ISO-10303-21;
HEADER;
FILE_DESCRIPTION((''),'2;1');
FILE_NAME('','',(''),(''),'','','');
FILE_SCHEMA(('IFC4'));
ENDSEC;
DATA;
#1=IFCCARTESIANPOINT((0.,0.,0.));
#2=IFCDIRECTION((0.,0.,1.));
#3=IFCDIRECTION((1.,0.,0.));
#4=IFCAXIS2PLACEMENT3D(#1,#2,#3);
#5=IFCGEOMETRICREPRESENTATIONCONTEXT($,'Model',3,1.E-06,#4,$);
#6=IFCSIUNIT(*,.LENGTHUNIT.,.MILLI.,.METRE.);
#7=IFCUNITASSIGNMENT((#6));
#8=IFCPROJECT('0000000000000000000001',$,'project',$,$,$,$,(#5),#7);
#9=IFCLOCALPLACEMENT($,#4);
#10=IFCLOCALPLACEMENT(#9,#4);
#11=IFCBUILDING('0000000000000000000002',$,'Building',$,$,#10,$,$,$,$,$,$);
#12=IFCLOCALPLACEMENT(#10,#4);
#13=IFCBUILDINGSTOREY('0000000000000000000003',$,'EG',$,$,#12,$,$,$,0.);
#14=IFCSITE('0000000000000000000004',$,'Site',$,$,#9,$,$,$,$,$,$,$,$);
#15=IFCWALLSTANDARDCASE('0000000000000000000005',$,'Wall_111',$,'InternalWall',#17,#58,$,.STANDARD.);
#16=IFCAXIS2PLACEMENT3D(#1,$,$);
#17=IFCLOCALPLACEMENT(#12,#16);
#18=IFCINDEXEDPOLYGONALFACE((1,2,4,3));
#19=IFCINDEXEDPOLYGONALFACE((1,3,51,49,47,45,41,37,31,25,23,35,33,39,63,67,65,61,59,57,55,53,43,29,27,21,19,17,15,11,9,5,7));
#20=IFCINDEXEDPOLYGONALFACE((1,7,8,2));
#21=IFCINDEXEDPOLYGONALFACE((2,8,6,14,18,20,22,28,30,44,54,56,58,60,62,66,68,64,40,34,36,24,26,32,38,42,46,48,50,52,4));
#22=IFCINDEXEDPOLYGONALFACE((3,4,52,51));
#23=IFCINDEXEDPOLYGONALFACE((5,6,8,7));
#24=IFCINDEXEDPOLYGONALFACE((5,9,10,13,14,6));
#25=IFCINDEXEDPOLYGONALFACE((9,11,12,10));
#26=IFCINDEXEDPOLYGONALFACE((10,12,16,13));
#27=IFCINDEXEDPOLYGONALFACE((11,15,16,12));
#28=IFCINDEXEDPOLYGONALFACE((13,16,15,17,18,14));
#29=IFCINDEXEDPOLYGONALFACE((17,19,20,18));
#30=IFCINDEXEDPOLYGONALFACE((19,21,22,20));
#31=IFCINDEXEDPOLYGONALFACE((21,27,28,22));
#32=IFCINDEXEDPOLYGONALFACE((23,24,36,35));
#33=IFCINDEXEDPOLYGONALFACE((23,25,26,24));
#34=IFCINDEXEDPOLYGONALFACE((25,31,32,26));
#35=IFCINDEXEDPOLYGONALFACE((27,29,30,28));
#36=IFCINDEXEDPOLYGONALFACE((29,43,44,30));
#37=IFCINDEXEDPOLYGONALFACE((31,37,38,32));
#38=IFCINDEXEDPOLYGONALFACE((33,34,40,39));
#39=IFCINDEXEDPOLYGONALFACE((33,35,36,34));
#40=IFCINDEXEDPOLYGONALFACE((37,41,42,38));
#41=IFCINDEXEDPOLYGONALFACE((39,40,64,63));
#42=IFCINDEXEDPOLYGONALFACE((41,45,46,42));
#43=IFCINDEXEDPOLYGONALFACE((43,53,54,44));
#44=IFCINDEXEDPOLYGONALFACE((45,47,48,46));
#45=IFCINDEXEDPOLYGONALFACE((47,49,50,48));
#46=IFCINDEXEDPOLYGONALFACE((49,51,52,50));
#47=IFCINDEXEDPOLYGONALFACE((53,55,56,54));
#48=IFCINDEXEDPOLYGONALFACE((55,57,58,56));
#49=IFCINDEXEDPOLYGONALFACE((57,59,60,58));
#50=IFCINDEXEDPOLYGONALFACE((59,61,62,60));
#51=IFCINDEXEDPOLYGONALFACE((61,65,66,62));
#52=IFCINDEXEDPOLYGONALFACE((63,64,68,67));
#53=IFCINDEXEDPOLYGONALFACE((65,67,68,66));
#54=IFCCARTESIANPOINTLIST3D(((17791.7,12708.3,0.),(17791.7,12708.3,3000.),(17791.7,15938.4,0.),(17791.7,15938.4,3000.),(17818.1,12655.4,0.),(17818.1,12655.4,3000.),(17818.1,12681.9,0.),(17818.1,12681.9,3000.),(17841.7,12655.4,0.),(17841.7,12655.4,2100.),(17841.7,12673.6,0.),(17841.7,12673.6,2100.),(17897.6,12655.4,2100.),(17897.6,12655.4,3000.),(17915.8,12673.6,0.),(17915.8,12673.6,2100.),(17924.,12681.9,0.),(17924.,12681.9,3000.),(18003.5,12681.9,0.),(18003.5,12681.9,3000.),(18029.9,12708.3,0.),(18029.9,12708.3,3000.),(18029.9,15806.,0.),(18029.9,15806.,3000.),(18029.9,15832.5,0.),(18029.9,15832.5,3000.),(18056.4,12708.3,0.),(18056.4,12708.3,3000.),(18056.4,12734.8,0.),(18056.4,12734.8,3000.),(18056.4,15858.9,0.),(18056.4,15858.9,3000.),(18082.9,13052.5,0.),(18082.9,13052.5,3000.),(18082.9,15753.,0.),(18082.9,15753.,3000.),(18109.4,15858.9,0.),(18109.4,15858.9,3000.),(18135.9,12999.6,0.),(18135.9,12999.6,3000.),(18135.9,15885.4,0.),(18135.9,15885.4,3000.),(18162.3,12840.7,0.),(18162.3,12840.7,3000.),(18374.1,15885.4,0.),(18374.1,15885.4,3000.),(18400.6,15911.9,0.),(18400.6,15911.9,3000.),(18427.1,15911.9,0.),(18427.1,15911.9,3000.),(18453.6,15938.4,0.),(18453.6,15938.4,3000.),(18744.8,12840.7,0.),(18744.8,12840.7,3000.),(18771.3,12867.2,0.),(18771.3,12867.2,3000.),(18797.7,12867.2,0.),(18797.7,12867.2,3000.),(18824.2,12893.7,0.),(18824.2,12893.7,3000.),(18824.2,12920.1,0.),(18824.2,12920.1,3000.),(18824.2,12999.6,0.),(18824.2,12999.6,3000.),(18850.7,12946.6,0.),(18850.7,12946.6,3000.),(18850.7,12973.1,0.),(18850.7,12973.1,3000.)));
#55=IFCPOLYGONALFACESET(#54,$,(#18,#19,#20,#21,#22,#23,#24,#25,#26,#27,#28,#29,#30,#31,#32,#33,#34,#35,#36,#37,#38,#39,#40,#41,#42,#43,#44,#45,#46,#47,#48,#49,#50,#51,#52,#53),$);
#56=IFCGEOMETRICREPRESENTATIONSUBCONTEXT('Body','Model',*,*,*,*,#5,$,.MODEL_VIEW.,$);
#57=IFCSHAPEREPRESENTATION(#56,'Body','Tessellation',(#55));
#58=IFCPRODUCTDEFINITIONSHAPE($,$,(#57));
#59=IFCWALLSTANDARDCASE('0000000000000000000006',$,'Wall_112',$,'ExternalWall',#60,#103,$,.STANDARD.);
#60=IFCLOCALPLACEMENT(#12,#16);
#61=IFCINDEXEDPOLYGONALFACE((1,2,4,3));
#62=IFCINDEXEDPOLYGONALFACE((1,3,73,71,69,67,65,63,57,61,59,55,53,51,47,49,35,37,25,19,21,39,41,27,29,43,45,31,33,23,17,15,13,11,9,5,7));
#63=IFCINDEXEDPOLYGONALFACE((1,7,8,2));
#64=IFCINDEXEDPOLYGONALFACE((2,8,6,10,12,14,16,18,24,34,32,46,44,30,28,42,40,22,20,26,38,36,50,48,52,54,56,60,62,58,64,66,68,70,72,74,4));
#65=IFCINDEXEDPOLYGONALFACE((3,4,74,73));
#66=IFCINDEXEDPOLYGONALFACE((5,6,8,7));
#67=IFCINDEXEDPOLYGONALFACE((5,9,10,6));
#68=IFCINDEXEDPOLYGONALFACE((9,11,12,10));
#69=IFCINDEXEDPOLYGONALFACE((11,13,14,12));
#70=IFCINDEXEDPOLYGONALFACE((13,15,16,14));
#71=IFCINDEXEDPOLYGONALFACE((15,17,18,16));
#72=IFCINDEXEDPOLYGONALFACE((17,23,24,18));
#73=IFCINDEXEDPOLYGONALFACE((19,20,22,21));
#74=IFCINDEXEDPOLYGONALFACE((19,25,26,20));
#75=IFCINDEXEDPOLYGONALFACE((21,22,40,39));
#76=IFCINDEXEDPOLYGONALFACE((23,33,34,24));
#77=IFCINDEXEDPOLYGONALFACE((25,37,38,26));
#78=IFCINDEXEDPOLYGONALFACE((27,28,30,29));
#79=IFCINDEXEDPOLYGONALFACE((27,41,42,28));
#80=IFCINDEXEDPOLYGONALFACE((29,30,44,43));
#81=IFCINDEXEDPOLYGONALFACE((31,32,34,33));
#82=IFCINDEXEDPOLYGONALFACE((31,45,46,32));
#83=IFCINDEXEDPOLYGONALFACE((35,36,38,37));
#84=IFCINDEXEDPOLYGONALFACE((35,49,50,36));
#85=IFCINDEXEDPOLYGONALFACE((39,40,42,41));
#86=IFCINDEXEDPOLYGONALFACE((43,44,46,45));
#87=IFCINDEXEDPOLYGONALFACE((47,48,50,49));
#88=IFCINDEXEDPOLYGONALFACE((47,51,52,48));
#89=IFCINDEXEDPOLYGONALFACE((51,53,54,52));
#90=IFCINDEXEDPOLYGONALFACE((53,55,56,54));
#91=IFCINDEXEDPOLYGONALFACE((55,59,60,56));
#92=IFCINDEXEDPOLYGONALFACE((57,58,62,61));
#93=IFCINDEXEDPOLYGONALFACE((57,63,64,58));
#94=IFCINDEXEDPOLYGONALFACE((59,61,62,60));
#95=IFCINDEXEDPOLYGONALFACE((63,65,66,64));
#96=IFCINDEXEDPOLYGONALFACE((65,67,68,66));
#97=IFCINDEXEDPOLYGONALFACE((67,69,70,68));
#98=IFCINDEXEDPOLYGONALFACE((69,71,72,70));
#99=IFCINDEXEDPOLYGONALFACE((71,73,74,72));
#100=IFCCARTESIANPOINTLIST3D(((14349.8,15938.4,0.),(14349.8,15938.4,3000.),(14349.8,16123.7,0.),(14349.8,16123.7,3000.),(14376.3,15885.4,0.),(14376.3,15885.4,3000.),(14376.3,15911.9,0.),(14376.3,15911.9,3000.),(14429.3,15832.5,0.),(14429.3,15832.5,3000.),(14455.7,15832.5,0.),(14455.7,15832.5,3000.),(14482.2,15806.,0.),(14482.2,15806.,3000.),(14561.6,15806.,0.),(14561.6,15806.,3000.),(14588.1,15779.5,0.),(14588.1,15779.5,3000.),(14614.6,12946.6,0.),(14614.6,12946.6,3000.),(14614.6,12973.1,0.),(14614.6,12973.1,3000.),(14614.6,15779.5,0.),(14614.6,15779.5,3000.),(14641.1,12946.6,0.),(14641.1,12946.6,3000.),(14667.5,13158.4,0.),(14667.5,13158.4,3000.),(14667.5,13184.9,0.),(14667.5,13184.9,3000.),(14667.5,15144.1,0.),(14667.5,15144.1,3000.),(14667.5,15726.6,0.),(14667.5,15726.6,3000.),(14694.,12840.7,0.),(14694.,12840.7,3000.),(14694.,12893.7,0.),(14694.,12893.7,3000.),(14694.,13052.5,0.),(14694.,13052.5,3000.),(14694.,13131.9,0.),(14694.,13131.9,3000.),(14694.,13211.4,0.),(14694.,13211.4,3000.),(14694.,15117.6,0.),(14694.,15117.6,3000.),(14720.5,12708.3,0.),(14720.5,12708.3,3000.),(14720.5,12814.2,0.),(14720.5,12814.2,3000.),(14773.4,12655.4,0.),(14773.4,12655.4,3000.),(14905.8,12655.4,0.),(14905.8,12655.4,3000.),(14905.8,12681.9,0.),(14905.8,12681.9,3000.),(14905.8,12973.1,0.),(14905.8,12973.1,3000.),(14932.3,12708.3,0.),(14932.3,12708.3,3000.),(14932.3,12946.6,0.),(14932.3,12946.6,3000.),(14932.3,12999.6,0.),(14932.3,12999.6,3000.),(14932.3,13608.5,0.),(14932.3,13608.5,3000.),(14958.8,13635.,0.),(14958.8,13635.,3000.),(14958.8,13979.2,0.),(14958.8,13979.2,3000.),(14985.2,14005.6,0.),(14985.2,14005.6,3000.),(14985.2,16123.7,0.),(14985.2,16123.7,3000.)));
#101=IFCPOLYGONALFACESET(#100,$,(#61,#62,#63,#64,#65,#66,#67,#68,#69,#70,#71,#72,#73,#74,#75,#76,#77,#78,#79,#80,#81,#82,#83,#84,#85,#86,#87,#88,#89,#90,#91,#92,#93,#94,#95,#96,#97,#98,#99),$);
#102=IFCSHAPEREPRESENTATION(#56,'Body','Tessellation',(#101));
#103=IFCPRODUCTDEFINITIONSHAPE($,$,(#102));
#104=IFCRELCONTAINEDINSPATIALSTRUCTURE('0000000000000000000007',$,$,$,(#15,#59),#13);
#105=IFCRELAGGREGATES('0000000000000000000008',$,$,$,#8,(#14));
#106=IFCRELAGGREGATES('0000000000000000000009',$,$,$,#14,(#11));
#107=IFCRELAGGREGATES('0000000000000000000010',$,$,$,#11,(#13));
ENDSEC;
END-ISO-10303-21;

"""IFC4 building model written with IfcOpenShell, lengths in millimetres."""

from ifc_helpers import new_model, si_unit, frame, origin_with_axes, place, context, subcontext, project, spatial, polyline, rectangle, outline, extrude, element, save


model = new_model("IFC4")

# Units and contexts
model_context = context("Model", 3, precision=1e-06, world=origin_with_axes())
body_context = subcontext(model_context, "Body", "Model", "MODEL_VIEW")
ifc_project = project(units=[si_unit("LENGTHUNIT", "METRE", prefix="MILLI")], contexts=[model_context])

# Site, building, storey
site_placement = place(None, origin_with_axes())
site = spatial("IfcSite", under=ifc_project, at=site_placement, Name="Site")
building_placement = place(site_placement, origin_with_axes())
building = spatial("IfcBuilding", under=site, at=building_placement, Name="Building")
storey_placement = place(building_placement, origin_with_axes())
storey = spatial("IfcBuildingStorey", under=building, at=storey_placement, Name="EG", Elevation=0.0)

# Wall, opening
wall_1_placement = place(storey_placement, origin_with_axes())
wall_1 = element("IfcWallStandardCase", 1, at=wall_1_placement, inside=storey, Name="Wall_111", ObjectType="InternalWall", PredefinedType="STANDARD", context=body_context, shape_type="SweptSolid", body=[
    extrude(outline(polyline([(17818.1, 12655.4, 0.0), (17818.1, 12681.9, 0.0), (17791.7, 12708.3, 0.0), (17791.7, 15938.4, 0.0), (18453.6, 15938.4, 0.0), (18427.1, 15911.9, 0.0), (18400.6, 15911.9, 0.0), (18374.1, 15885.4, 0.0), (18135.9, 15885.4, 0.0), (18109.4, 15858.9, 0.0), (18056.4, 15858.9, 0.0), (18029.9, 15832.5, 0.0), (18029.9, 15806.0, 0.0), (18082.9, 15753.0, 0.0), (18082.9, 13052.5, 0.0), (18135.9, 12999.6, 0.0), (18824.2, 12999.6, 0.0), (18850.7, 12973.1, 0.0), (18850.7, 12946.6, 0.0), (18824.2, 12920.1, 0.0), (18824.2, 12893.7, 0.0), (18797.7, 12867.2, 0.0), (18771.3, 12867.2, 0.0), (18744.8, 12840.7, 0.0), (18162.3, 12840.7, 0.0), (18056.4, 12734.8, 0.0), (18056.4, 12708.3, 0.0), (18029.9, 12708.3, 0.0), (18003.5, 12681.9, 0.0), (17924.0, 12681.9, 0.0), (17897.6, 12655.4, 0.0), (17818.1, 12655.4, 0.0)])), origin_with_axes(), (0.0, 0.0, 1.0), 3000.0),
])
opening_1_placement = place(wall_1_placement, origin_with_axes())
element("IfcOpeningElement", 2, at=opening_1_placement, inside=storey, cuts=wall_1, context=body_context, shape_type="SweptSolid", body=[
    extrude(rectangle(XDim=953.1, YDim=300.0), frame((17991.7, 12197.0, 0.0), z_axis=(0.0, 0.0, 1.0), x_axis=(0.0, 1.0, 0.0)), (0.0, 0.0, 1.0), 2100.0),
])

# Wall
for number, where, z_axis, x_axis, name in (
    (3, (0.0, 0.0, 0.0), (0.0, 0.0, 1.0), (1.0, 0.0, 0.0), "Wall_112"),
):
    element("IfcWallStandardCase", number, at=place(storey_placement, frame(where, z_axis=z_axis, x_axis=x_axis)), inside=storey, Name=name, ObjectType="ExternalWall", PredefinedType="STANDARD", context=body_context, shape_type="SweptSolid", body=[
        extrude(outline(polyline([(14773.4, 12655.4, 0.0), (14720.5, 12708.3, 0.0), (14720.5, 12814.2, 0.0), (14694.0, 12840.7, 0.0), (14694.0, 12893.7, 0.0), (14641.1, 12946.6, 0.0), (14614.6, 12946.6, 0.0), (14614.6, 12973.1, 0.0), (14694.0, 13052.5, 0.0), (14694.0, 13131.9, 0.0), (14667.5, 13158.4, 0.0), (14667.5, 13184.9, 0.0), (14694.0, 13211.4, 0.0), (14694.0, 15117.6, 0.0), (14667.5, 15144.1, 0.0), (14667.5, 15726.6, 0.0), (14614.6, 15779.5, 0.0), (14588.1, 15779.5, 0.0), (14561.6, 15806.0, 0.0), (14482.2, 15806.0, 0.0), (14455.7, 15832.5, 0.0), (14429.3, 15832.5, 0.0), (14376.3, 15885.4, 0.0), (14376.3, 15911.9, 0.0), (14349.8, 15938.4, 0.0), (14349.8, 16123.7, 0.0), (14985.2, 16123.7, 0.0), (14985.2, 14005.6, 0.0), (14958.8, 13979.2, 0.0), (14958.8, 13635.0, 0.0), (14932.3, 13608.5, 0.0), (14932.3, 12999.6, 0.0), (14905.8, 12973.1, 0.0), (14932.3, 12946.6, 0.0), (14932.3, 12708.3, 0.0), (14905.8, 12681.9, 0.0), (14905.8, 12655.4, 0.0), (14773.4, 12655.4, 0.0)])), origin_with_axes(), (0.0, 0.0, 1.0), 3000.0),
    ])

save(model, "model.ifc")
